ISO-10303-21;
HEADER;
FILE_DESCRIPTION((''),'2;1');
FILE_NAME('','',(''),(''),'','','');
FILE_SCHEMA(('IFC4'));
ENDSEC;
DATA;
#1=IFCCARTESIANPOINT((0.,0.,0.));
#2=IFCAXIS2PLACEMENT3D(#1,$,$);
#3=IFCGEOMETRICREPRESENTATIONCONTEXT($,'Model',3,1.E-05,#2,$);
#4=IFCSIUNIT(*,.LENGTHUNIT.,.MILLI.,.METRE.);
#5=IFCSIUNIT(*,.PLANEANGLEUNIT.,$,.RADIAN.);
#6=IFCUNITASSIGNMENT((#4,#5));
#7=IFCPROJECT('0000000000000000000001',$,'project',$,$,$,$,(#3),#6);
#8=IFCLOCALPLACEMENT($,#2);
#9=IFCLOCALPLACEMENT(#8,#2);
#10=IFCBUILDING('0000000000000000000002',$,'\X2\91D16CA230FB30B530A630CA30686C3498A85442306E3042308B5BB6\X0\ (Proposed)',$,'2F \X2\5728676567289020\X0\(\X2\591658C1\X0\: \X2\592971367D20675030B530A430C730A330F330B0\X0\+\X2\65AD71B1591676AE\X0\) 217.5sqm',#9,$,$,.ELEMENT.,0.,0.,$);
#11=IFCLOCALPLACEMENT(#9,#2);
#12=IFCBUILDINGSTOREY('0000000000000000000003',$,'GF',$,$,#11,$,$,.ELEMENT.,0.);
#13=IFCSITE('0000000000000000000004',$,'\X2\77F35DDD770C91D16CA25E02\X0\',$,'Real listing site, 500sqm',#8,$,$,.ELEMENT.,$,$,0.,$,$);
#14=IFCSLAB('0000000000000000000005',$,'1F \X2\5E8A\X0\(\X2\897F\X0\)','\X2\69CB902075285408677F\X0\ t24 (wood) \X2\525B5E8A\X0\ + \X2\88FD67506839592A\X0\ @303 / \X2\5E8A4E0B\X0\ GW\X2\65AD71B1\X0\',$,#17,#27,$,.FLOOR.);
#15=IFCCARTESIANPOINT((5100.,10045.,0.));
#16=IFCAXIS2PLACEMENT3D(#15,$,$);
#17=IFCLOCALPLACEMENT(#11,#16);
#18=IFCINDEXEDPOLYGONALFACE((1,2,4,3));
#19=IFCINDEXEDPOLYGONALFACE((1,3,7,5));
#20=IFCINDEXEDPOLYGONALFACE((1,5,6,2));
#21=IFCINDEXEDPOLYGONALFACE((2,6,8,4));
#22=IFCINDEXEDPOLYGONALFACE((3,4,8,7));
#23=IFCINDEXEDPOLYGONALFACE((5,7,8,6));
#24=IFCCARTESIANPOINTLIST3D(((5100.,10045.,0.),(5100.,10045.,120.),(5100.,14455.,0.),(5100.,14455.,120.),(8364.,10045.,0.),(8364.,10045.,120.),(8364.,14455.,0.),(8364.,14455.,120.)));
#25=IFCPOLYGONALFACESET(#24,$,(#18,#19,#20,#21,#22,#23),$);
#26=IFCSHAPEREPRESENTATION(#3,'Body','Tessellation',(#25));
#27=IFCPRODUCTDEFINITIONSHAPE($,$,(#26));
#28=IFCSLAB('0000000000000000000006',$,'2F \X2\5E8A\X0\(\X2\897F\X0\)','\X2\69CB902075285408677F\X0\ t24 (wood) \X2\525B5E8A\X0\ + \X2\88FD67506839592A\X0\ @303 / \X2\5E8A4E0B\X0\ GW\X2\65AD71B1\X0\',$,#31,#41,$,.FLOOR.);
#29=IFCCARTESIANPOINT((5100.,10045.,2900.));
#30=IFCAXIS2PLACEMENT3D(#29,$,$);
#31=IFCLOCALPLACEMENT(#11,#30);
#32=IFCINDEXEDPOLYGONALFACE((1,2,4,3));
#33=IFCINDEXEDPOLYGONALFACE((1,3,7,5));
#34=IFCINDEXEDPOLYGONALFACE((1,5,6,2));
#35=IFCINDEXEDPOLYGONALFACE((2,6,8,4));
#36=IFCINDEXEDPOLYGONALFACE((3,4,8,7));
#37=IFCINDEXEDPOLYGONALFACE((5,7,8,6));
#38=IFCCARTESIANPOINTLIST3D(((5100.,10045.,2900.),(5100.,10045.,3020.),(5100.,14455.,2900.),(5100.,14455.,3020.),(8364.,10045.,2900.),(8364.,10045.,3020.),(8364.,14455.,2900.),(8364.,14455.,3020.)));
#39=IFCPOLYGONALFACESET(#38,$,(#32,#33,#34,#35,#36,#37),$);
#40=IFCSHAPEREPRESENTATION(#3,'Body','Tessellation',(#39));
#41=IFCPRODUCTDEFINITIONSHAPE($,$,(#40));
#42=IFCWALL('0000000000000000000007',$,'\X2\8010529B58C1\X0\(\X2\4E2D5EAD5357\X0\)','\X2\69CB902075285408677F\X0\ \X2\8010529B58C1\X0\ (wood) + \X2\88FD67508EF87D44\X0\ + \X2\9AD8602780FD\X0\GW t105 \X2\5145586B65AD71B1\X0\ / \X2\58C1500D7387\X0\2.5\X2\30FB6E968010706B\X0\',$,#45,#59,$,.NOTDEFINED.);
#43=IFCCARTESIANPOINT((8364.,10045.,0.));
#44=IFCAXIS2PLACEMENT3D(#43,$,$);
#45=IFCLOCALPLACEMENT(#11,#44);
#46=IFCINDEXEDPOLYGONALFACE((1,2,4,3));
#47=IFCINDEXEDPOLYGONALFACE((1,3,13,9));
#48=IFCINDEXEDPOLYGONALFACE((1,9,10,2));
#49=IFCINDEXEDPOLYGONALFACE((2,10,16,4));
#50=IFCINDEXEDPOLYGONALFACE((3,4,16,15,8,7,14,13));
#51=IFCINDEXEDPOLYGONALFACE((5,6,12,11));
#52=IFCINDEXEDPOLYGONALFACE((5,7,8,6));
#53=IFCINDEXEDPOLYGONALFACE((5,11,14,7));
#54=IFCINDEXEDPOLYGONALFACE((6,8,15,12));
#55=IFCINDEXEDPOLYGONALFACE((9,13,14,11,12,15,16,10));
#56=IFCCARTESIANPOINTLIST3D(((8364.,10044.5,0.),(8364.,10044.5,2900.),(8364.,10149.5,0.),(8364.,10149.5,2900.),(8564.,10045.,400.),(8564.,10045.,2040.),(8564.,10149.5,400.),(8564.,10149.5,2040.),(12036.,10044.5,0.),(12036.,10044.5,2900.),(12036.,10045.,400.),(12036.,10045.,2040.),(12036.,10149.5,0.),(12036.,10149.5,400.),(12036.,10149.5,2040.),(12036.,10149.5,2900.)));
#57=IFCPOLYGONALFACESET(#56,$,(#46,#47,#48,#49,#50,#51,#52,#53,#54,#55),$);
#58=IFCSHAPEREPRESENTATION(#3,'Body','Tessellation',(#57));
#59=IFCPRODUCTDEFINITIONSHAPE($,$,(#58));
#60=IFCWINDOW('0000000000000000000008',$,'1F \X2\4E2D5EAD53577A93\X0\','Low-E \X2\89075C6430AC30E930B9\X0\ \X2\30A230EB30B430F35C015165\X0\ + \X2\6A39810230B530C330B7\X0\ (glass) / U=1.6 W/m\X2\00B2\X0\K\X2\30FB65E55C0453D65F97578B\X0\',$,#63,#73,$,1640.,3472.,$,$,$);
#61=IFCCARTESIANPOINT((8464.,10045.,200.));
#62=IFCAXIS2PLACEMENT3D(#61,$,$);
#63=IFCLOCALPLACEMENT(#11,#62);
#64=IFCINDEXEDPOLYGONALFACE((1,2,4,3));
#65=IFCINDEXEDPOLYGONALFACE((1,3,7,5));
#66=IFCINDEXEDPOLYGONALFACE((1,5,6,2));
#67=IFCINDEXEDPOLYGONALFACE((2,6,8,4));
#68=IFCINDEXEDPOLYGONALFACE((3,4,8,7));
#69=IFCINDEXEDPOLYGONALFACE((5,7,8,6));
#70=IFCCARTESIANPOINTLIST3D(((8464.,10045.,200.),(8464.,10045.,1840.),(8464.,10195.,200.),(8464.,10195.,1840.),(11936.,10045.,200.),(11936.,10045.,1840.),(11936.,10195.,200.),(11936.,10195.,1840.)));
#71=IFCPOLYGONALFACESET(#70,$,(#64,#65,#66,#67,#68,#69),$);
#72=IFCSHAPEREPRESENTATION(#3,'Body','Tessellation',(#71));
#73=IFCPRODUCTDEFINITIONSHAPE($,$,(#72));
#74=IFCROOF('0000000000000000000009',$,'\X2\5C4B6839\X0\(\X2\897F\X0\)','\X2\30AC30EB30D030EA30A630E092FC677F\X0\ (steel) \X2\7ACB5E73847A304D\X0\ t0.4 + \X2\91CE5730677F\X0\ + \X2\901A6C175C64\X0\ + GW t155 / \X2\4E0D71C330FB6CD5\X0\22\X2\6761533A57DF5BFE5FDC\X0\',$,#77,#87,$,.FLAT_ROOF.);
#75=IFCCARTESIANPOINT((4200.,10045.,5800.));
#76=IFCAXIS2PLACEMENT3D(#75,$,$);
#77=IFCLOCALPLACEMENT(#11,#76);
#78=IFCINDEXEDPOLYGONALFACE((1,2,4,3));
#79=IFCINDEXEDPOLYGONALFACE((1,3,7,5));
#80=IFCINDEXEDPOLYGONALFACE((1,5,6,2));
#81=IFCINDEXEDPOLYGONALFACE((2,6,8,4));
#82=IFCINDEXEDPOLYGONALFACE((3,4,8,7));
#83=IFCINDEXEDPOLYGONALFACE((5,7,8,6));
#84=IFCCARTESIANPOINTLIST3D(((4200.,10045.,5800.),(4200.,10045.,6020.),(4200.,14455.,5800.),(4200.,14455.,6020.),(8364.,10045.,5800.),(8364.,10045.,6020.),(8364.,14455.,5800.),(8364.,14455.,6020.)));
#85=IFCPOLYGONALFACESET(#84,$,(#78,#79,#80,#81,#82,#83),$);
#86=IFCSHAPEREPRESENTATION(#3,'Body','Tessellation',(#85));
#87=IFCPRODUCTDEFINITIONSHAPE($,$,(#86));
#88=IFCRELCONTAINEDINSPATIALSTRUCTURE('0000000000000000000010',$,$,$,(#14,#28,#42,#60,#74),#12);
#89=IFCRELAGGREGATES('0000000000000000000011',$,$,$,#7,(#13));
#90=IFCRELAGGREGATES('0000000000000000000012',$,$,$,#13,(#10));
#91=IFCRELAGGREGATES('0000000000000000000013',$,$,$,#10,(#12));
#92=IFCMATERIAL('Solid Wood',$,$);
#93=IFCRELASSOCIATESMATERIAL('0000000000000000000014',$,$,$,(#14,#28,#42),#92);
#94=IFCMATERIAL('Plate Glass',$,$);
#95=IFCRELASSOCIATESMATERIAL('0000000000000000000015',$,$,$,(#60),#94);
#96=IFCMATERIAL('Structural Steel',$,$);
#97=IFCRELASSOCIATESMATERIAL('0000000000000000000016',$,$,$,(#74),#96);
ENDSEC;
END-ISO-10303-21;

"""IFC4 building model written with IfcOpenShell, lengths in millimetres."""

from ifc_helpers import new_model, si_unit, frame, frame_2d, origin, place, context, project, spatial, rectangle, extrude, material, element, fill, save


model = new_model("IFC4")

# Units and contexts
model_context = context("Model", 3, precision=1e-05, world=origin())
ifc_project = project(units=[si_unit("LENGTHUNIT", "METRE", prefix="MILLI"), si_unit("PLANEANGLEUNIT", "RADIAN")], contexts=[model_context])

# Site, building, storey
site_placement = place(None, origin())
site = spatial("IfcSite", under=ifc_project, at=site_placement, Name="石川県金沢市", ObjectType="Real listing site, 500sqm", CompositionType="ELEMENT", RefElevation=0.0)
building_placement = place(site_placement, origin())
building = spatial("IfcBuilding", under=site, at=building_placement, Name="金沢・サウナと水風呂のある家 (Proposed)", ObjectType="2F 在来木造(外壁: 天然素材サイディング+断熱外皮) 217.5sqm", CompositionType="ELEMENT", ElevationOfRefHeight=0.0, ElevationOfTerrain=0.0)
storey_placement = place(building_placement, origin())
storey = spatial("IfcBuildingStorey", under=building, at=storey_placement, Name="GF", CompositionType="ELEMENT", Elevation=0.0)

# Shared definitions
ifc_material_1 = material(Name="Solid Wood")

# Slabs
slab_1_placement = place(storey_placement, frame((5100.0, 10045.0, 0.0)))
element("IfcSlab", 1, at=slab_1_placement, inside=storey, material=ifc_material_1, Name="1F 床(西)", Description="構造用合板 t24 (wood) 剛床 + 製材根太 @303 / 床下 GW断熱", PredefinedType="FLOOR", context=model_context, shape_type="SweptSolid", body=[
    extrude(rectangle(XDim=3264.0, YDim=4410.0, at=frame_2d((1632.0, 2205.0))), frame((5100.0, 10045.0, 0.0)), (0.0, 0.0, 1.0), 120.0),
])
slab_2_placement = place(storey_placement, frame((5100.0, 10045.0, 2900.0)))
element("IfcSlab", 2, at=slab_2_placement, inside=storey, material=ifc_material_1, Name="2F 床(西)", Description="構造用合板 t24 (wood) 剛床 + 製材根太 @303 / 床下 GW断熱", PredefinedType="FLOOR", context=model_context, shape_type="SweptSolid", body=[
    extrude(rectangle(XDim=3264.0, YDim=4410.0, at=frame_2d((1632.0, 2205.0))), frame((5100.0, 10045.0, 2900.0)), (0.0, 0.0, 1.0), 120.0),
])

# Wall, opening, window
wall_1_placement = place(storey_placement, frame((8364.0, 10045.0, 0.0)))
wall_1 = element("IfcWall", 3, at=wall_1_placement, inside=storey, material=ifc_material_1, Name="耐力壁(中庭南)", Description="構造用合板 耐力壁 (wood) + 製材軸組 + 高性能GW t105 充填断熱 / 壁倍率2.5・準耐火", PredefinedType="NOTDEFINED", context=model_context, shape_type="SweptSolid", body=[
    extrude(rectangle(XDim=3672.0, YDim=105.0, at=frame_2d((1836.0, 52.0))), frame((8364.0, 10045.0, 0.0)), (0.0, 0.0, 1.0), 2900.0),
])
opening_placement = place(storey_placement, frame((8464.0, 10045.0, 200.0)))
opening = element("IfcOpeningElement", 4, at=opening_placement, cuts=wall_1, PredefinedType="NOTDEFINED", context=model_context, shape_type="SweptSolid", body=[
    extrude(rectangle(XDim=3472.0, YDim=150.0, at=frame_2d((1736.0, 75.0))), frame((8464.0, 10045.0, 200.0)), (0.0, 0.0, 1.0), 1640.0),
])
ifc_material_2 = material(Name="Plate Glass")
window_placement = place(storey_placement, frame((8464.0, 10045.0, 200.0)))
window = element("IfcWindow", 5, at=window_placement, inside=storey, material=ifc_material_2, Name="1F 中庭南窓", Description="Low-E 複層ガラス アルゴン封入 + 樹脂サッシ (glass) / U=1.6 W/m²K・日射取得型", OverallHeight=1640.0, OverallWidth=3472.0, context=model_context, shape_type="SweptSolid", body=[
    extrude(rectangle(XDim=3472.0, YDim=150.0, at=frame_2d((1736.0, 75.0))), frame((8464.0, 10045.0, 200.0)), (0.0, 0.0, 1.0), 1640.0),
])
fill(opening, window)

# Roof
ifc_material_3 = material(Name="Structural Steel")
for number, where, name in (
    (6, (4200.0, 10045.0, 5800.0), "屋根(西)"),
):
    element("IfcRoof", number, at=place(storey_placement, frame(where)), inside=storey, material=ifc_material_3, Name=name, Description="ガルバリウム鋼板 (steel) 立平葺き t0.4 + 野地板 + 通気層 + GW t155 / 不燃・法22条区域対応", PredefinedType="FLAT_ROOF", context=model_context, shape_type="SweptSolid", body=[
        extrude(rectangle(XDim=4164.0, YDim=4410.0, at=frame_2d((2082.0, 2205.0))), frame((4200.0, 10045.0, 5800.0)), (0.0, 0.0, 1.0), 220.0),
    ])

save(model, "model.ifc")
